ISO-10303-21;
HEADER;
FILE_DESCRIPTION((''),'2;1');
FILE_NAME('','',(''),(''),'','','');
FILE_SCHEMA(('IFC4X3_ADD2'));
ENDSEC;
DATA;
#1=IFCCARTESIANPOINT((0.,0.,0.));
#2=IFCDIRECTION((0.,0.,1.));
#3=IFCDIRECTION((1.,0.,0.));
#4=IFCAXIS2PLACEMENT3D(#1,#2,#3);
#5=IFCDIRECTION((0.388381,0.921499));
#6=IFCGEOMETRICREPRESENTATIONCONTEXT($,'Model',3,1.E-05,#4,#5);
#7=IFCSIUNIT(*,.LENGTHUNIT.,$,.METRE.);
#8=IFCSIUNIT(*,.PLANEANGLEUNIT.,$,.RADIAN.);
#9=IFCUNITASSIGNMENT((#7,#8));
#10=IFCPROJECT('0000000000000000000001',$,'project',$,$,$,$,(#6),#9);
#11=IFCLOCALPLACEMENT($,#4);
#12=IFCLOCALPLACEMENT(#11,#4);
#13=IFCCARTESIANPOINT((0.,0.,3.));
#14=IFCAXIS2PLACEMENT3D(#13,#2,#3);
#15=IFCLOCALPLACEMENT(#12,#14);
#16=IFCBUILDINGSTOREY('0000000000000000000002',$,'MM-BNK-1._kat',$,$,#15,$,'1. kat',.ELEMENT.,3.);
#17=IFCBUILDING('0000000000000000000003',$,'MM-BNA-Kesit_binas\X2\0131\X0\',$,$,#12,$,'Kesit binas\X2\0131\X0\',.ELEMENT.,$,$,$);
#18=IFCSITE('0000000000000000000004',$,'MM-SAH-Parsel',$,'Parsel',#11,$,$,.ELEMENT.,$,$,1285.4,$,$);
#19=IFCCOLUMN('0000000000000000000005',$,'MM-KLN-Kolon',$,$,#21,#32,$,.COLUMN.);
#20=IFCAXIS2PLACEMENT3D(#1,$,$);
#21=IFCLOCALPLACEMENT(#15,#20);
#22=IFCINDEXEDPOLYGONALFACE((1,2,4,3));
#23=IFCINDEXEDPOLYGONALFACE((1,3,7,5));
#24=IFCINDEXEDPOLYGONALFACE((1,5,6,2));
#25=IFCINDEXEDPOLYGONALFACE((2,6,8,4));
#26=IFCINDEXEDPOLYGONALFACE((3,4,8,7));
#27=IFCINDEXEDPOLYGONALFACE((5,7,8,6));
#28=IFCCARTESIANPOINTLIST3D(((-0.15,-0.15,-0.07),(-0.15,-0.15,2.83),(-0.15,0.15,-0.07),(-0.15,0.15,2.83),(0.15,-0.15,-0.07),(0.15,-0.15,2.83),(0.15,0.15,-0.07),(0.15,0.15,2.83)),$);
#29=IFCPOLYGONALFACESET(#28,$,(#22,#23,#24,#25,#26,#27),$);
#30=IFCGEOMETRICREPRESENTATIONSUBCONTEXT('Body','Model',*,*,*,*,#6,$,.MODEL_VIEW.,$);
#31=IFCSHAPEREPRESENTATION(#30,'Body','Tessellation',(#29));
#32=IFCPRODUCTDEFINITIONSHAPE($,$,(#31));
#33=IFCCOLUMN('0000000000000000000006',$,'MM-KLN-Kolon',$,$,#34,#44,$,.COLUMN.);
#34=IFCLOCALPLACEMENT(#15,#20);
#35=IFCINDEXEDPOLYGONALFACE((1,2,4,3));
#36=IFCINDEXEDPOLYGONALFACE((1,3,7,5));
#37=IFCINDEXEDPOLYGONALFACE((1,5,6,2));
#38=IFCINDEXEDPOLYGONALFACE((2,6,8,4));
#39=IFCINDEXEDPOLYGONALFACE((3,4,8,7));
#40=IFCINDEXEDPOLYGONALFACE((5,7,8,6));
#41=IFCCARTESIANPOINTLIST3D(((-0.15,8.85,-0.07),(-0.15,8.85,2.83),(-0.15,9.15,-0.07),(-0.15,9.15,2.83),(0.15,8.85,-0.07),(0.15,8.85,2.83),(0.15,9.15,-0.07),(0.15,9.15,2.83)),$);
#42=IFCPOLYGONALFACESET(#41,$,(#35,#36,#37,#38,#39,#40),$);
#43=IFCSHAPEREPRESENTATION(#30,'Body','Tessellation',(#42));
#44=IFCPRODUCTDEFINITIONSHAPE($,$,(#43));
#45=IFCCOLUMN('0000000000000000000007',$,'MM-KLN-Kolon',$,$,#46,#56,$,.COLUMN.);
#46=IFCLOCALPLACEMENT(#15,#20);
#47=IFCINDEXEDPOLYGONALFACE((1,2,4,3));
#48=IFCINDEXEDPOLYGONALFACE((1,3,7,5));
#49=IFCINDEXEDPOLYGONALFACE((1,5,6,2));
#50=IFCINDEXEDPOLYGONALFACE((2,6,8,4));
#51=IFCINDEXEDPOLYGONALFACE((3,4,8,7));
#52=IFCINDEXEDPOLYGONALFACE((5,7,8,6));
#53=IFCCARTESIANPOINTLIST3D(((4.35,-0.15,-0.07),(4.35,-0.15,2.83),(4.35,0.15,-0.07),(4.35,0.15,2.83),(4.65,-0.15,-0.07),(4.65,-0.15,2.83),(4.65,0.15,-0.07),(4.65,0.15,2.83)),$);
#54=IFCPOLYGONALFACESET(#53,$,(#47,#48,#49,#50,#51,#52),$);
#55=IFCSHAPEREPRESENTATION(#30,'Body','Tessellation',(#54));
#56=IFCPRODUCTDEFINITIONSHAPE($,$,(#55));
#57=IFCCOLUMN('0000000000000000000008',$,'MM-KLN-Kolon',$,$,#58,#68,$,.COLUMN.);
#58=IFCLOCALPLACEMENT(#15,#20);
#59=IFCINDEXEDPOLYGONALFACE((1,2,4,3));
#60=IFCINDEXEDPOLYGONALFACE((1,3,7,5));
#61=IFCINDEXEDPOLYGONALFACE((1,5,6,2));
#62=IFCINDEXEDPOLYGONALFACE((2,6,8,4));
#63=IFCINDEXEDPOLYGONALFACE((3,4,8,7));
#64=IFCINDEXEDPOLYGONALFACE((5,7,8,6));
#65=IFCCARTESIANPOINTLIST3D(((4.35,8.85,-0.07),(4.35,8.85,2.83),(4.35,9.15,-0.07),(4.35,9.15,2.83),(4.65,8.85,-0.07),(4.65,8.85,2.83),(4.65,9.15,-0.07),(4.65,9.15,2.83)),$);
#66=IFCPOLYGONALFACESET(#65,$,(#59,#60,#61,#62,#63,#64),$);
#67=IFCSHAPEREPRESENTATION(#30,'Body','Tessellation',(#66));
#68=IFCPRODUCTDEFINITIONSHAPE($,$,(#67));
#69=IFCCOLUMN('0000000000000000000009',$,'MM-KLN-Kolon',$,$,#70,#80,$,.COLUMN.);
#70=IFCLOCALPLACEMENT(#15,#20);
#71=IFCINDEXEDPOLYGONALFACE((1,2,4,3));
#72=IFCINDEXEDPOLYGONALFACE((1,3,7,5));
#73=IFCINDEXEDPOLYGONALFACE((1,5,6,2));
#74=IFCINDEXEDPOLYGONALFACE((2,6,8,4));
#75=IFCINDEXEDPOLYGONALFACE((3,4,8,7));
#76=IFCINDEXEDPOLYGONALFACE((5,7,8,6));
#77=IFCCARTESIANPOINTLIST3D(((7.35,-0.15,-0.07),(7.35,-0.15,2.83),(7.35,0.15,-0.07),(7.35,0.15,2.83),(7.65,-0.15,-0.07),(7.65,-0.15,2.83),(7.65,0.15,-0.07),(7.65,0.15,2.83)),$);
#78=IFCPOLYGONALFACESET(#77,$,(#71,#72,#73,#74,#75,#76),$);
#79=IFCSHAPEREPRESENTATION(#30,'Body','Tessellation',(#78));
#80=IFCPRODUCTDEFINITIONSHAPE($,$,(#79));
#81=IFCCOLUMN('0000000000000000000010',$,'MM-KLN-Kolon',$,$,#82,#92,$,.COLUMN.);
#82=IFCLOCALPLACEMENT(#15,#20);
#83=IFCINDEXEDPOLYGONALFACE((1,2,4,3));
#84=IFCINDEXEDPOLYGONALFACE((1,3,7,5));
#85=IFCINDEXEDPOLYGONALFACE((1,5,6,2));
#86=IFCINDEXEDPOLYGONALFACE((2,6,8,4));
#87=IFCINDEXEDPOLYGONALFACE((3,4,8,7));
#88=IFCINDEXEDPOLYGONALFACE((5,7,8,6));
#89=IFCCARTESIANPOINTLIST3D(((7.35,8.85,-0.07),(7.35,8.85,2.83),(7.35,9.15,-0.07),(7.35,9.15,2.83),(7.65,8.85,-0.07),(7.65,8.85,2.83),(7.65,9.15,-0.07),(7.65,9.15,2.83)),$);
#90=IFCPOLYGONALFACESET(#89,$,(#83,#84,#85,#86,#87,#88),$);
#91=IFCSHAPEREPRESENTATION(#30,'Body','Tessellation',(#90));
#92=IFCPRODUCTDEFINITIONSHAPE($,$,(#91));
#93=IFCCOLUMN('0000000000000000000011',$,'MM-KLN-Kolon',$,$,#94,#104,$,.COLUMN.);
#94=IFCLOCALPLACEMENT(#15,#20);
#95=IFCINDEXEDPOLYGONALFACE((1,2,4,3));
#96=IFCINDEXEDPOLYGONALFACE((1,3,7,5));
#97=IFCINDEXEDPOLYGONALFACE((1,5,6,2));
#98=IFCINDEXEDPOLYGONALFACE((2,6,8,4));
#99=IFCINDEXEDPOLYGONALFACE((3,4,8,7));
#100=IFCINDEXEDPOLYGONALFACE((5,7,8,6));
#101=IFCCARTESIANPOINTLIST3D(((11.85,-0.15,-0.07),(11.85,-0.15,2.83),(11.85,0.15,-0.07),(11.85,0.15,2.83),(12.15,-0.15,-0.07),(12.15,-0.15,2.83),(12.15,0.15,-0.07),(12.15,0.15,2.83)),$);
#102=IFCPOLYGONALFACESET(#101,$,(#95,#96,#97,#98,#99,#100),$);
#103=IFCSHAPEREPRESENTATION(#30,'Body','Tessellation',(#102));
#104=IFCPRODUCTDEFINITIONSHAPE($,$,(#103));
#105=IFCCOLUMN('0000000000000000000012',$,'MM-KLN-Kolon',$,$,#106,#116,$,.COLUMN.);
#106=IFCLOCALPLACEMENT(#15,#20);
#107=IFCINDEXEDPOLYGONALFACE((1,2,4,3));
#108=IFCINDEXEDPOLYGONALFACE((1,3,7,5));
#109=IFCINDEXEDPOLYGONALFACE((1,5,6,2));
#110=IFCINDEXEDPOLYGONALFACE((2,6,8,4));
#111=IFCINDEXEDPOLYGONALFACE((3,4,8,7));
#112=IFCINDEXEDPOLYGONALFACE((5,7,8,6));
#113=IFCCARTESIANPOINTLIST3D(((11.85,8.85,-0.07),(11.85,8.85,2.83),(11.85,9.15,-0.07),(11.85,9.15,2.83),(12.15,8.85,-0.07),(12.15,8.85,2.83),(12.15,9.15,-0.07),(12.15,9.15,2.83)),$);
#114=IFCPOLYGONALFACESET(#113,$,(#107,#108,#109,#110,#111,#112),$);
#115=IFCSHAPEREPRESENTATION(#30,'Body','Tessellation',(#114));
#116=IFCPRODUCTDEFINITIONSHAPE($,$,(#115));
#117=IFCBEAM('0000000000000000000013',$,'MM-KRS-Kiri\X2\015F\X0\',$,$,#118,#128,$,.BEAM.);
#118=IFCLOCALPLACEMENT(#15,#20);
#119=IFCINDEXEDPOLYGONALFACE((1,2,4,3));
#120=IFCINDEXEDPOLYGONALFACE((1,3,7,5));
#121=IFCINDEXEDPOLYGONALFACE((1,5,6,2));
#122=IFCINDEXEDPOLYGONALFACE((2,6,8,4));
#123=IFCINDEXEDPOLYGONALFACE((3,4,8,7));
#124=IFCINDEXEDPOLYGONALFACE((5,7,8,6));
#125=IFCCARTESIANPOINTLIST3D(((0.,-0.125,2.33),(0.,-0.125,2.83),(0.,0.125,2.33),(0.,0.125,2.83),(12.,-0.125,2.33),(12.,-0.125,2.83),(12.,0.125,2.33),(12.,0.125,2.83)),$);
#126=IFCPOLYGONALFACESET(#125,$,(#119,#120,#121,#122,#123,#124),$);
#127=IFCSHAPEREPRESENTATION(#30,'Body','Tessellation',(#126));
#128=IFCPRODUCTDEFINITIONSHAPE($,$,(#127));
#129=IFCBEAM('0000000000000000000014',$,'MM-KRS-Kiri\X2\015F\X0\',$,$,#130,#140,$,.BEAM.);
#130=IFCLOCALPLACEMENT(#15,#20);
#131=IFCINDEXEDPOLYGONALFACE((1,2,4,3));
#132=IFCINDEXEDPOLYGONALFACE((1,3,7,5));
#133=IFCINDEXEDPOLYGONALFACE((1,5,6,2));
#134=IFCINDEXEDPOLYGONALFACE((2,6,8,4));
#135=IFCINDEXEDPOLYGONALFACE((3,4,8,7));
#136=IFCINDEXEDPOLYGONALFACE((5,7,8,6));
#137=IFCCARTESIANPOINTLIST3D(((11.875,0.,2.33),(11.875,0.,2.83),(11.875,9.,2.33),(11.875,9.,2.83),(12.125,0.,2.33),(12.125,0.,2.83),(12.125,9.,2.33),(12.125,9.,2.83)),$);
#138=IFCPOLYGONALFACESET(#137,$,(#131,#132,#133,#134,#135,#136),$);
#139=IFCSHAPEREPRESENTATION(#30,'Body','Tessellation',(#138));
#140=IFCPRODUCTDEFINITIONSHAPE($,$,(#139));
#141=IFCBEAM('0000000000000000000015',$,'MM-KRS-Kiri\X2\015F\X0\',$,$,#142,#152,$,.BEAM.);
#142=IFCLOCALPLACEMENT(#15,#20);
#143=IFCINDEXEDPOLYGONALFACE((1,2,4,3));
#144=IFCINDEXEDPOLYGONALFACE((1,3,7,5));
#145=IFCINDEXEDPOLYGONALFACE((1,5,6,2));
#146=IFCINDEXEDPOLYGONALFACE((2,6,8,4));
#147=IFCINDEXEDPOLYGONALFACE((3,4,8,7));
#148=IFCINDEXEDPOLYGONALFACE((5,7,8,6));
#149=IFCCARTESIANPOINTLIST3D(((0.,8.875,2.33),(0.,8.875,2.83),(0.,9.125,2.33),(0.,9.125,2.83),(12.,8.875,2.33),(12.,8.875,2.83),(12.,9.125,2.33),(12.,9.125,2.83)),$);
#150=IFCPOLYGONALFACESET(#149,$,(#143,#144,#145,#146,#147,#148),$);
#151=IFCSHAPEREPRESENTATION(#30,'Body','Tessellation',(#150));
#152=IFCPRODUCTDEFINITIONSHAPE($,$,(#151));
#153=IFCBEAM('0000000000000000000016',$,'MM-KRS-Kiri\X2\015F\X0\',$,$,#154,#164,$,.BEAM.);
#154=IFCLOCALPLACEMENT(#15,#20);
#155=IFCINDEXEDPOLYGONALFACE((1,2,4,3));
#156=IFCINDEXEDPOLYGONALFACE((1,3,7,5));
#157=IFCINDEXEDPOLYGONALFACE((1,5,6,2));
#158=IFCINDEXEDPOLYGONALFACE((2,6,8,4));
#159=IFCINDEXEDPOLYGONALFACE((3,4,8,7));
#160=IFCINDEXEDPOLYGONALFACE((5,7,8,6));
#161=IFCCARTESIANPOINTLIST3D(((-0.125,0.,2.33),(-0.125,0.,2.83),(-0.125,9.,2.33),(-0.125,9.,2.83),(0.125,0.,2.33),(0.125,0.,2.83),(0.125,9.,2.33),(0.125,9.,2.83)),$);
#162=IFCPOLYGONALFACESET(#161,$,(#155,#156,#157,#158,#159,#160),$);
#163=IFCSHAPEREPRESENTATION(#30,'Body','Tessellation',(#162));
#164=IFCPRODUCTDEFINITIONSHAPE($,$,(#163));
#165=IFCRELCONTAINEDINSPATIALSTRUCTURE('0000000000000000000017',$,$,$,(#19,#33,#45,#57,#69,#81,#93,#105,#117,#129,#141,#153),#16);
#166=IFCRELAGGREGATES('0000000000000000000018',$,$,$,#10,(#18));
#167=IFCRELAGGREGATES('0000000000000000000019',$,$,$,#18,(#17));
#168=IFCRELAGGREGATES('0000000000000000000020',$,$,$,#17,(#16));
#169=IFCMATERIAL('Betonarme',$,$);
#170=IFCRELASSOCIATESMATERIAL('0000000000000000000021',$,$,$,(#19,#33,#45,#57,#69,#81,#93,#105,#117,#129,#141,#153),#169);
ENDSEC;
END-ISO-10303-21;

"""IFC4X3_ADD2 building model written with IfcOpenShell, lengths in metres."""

from ifc_helpers import new_model, si_unit, direction, frame, origin_with_axes, place, context, subcontext, project, spatial, polyline, outline, extrude, material, element, save


model = new_model("IFC4X3_ADD2")

# Units and contexts
model_context = context("Model", 3, precision=1e-05, world=origin_with_axes(), true_north=direction((0.388381, 0.921499)))
body_context = subcontext(model_context, "Body", "Model", "MODEL_VIEW")
ifc_project = project(units=[si_unit("LENGTHUNIT", "METRE"), si_unit("PLANEANGLEUNIT", "RADIAN")], contexts=[model_context])

# Site, building, storey
site_placement = place(None, origin_with_axes())
site = spatial("IfcSite", under=ifc_project, at=site_placement, Name="MM-SAH-Parsel", ObjectType="Parsel", CompositionType="ELEMENT", RefElevation=1285.4)
building_placement = place(site_placement, origin_with_axes())
building = spatial("IfcBuilding", under=site, at=building_placement, Name="MM-BNA-Kesit_binası", LongName="Kesit binası", CompositionType="ELEMENT")
storey_placement = place(building_placement, frame((0.0, 0.0, 3.0), z_axis=(0.0, 0.0, 1.0), x_axis=(1.0, 0.0, 0.0)))
storey = spatial("IfcBuildingStorey", under=building, at=storey_placement, Name="MM-BNK-1._kat", LongName="1. kat", CompositionType="ELEMENT", Elevation=3.0)

# Columns
ifc_material_1 = material(Name="Betonarme")
column_1_placement = place(storey_placement, origin_with_axes())
element("IfcColumn", 1, at=column_1_placement, inside=storey, material=ifc_material_1, Name="MM-KLN-Kolon", PredefinedType="COLUMN", context=body_context, shape_type="SweptSolid", body=[
    extrude(outline(polyline([(-0.15, -0.15), (0.15, -0.15), (0.15, 0.15), (-0.15, 0.15), (-0.15, -0.15)])), frame((0.0, 0.0, -0.07)), (0.0, 0.0, 1.0), 2.9),
])
column_2_placement = place(storey_placement, origin_with_axes())
element("IfcColumn", 2, at=column_2_placement, inside=storey, material=ifc_material_1, Name="MM-KLN-Kolon", PredefinedType="COLUMN", context=body_context, shape_type="SweptSolid", body=[
    extrude(outline(polyline([(-0.15, 8.85), (0.15, 8.85), (0.15, 9.15), (-0.15, 9.15), (-0.15, 8.85)])), frame((0.0, 0.0, -0.07)), (0.0, 0.0, 1.0), 2.9),
])
column_3_placement = place(storey_placement, origin_with_axes())
element("IfcColumn", 3, at=column_3_placement, inside=storey, material=ifc_material_1, Name="MM-KLN-Kolon", PredefinedType="COLUMN", context=body_context, shape_type="SweptSolid", body=[
    extrude(outline(polyline([(4.35, -0.15), (4.65, -0.15), (4.65, 0.15), (4.35, 0.15), (4.35, -0.15)])), frame((0.0, 0.0, -0.07)), (0.0, 0.0, 1.0), 2.9),
])
column_4_placement = place(storey_placement, origin_with_axes())
element("IfcColumn", 4, at=column_4_placement, inside=storey, material=ifc_material_1, Name="MM-KLN-Kolon", PredefinedType="COLUMN", context=body_context, shape_type="SweptSolid", body=[
    extrude(outline(polyline([(4.35, 8.85), (4.65, 8.85), (4.65, 9.15), (4.35, 9.15), (4.35, 8.85)])), frame((0.0, 0.0, -0.07)), (0.0, 0.0, 1.0), 2.9),
])
column_5_placement = place(storey_placement, origin_with_axes())
element("IfcColumn", 5, at=column_5_placement, inside=storey, material=ifc_material_1, Name="MM-KLN-Kolon", PredefinedType="COLUMN", context=body_context, shape_type="SweptSolid", body=[
    extrude(outline(polyline([(7.35, -0.15), (7.65, -0.15), (7.65, 0.15), (7.35, 0.15), (7.35, -0.15)])), frame((0.0, 0.0, -0.07)), (0.0, 0.0, 1.0), 2.9),
])
column_6_placement = place(storey_placement, origin_with_axes())
element("IfcColumn", 6, at=column_6_placement, inside=storey, material=ifc_material_1, Name="MM-KLN-Kolon", PredefinedType="COLUMN", context=body_context, shape_type="SweptSolid", body=[
    extrude(outline(polyline([(7.35, 8.85), (7.65, 8.85), (7.65, 9.15), (7.35, 9.15), (7.35, 8.85)])), frame((0.0, 0.0, -0.07)), (0.0, 0.0, 1.0), 2.9),
])
column_7_placement = place(storey_placement, origin_with_axes())
element("IfcColumn", 7, at=column_7_placement, inside=storey, material=ifc_material_1, Name="MM-KLN-Kolon", PredefinedType="COLUMN", context=body_context, shape_type="SweptSolid", body=[
    extrude(outline(polyline([(11.85, -0.15), (12.15, -0.15), (12.15, 0.15), (11.85, 0.15), (11.85, -0.15)])), frame((0.0, 0.0, -0.07)), (0.0, 0.0, 1.0), 2.9),
])
column_8_placement = place(storey_placement, origin_with_axes())
element("IfcColumn", 8, at=column_8_placement, inside=storey, material=ifc_material_1, Name="MM-KLN-Kolon", PredefinedType="COLUMN", context=body_context, shape_type="SweptSolid", body=[
    extrude(outline(polyline([(11.85, 8.85), (12.15, 8.85), (12.15, 9.15), (11.85, 9.15), (11.85, 8.85)])), frame((0.0, 0.0, -0.07)), (0.0, 0.0, 1.0), 2.9),
])

# Beams
beam_1_placement = place(storey_placement, origin_with_axes())
element("IfcBeam", 9, at=beam_1_placement, inside=storey, material=ifc_material_1, Name="MM-KRS-Kiriş", PredefinedType="BEAM", context=body_context, shape_type="SweptSolid", body=[
    extrude(outline(polyline([(0.0, 0.125), (12.0, 0.125), (12.0, -0.125), (0.0, -0.125), (0.0, 0.125)])), frame((0.0, 0.0, 2.33)), (0.0, 0.0, 1.0), 0.5),
])
beam_2_placement = place(storey_placement, origin_with_axes())
element("IfcBeam", 10, at=beam_2_placement, inside=storey, material=ifc_material_1, Name="MM-KRS-Kiriş", PredefinedType="BEAM", context=body_context, shape_type="SweptSolid", body=[
    extrude(outline(polyline([(11.875, 0.0), (11.875, 9.0), (12.125, 9.0), (12.125, 0.0), (11.875, 0.0)])), frame((0.0, 0.0, 2.33)), (0.0, 0.0, 1.0), 0.5),
])
beam_3_placement = place(storey_placement, origin_with_axes())
element("IfcBeam", 11, at=beam_3_placement, inside=storey, material=ifc_material_1, Name="MM-KRS-Kiriş", PredefinedType="BEAM", context=body_context, shape_type="SweptSolid", body=[
    extrude(outline(polyline([(12.0, 8.875), (0.0, 8.875), (0.0, 9.125), (12.0, 9.125), (12.0, 8.875)])), frame((0.0, 0.0, 2.33)), (0.0, 0.0, 1.0), 0.5),
])
beam_4_placement = place(storey_placement, origin_with_axes())
element("IfcBeam", 12, at=beam_4_placement, inside=storey, material=ifc_material_1, Name="MM-KRS-Kiriş", PredefinedType="BEAM", context=body_context, shape_type="SweptSolid", body=[
    extrude(outline(polyline([(0.125, 9.0), (0.125, 0.0), (-0.125, 0.0), (-0.125, 9.0), (0.125, 9.0)])), frame((0.0, 0.0, 2.33)), (0.0, 0.0, 1.0), 0.5),
])

save(model, "model.ifc")
